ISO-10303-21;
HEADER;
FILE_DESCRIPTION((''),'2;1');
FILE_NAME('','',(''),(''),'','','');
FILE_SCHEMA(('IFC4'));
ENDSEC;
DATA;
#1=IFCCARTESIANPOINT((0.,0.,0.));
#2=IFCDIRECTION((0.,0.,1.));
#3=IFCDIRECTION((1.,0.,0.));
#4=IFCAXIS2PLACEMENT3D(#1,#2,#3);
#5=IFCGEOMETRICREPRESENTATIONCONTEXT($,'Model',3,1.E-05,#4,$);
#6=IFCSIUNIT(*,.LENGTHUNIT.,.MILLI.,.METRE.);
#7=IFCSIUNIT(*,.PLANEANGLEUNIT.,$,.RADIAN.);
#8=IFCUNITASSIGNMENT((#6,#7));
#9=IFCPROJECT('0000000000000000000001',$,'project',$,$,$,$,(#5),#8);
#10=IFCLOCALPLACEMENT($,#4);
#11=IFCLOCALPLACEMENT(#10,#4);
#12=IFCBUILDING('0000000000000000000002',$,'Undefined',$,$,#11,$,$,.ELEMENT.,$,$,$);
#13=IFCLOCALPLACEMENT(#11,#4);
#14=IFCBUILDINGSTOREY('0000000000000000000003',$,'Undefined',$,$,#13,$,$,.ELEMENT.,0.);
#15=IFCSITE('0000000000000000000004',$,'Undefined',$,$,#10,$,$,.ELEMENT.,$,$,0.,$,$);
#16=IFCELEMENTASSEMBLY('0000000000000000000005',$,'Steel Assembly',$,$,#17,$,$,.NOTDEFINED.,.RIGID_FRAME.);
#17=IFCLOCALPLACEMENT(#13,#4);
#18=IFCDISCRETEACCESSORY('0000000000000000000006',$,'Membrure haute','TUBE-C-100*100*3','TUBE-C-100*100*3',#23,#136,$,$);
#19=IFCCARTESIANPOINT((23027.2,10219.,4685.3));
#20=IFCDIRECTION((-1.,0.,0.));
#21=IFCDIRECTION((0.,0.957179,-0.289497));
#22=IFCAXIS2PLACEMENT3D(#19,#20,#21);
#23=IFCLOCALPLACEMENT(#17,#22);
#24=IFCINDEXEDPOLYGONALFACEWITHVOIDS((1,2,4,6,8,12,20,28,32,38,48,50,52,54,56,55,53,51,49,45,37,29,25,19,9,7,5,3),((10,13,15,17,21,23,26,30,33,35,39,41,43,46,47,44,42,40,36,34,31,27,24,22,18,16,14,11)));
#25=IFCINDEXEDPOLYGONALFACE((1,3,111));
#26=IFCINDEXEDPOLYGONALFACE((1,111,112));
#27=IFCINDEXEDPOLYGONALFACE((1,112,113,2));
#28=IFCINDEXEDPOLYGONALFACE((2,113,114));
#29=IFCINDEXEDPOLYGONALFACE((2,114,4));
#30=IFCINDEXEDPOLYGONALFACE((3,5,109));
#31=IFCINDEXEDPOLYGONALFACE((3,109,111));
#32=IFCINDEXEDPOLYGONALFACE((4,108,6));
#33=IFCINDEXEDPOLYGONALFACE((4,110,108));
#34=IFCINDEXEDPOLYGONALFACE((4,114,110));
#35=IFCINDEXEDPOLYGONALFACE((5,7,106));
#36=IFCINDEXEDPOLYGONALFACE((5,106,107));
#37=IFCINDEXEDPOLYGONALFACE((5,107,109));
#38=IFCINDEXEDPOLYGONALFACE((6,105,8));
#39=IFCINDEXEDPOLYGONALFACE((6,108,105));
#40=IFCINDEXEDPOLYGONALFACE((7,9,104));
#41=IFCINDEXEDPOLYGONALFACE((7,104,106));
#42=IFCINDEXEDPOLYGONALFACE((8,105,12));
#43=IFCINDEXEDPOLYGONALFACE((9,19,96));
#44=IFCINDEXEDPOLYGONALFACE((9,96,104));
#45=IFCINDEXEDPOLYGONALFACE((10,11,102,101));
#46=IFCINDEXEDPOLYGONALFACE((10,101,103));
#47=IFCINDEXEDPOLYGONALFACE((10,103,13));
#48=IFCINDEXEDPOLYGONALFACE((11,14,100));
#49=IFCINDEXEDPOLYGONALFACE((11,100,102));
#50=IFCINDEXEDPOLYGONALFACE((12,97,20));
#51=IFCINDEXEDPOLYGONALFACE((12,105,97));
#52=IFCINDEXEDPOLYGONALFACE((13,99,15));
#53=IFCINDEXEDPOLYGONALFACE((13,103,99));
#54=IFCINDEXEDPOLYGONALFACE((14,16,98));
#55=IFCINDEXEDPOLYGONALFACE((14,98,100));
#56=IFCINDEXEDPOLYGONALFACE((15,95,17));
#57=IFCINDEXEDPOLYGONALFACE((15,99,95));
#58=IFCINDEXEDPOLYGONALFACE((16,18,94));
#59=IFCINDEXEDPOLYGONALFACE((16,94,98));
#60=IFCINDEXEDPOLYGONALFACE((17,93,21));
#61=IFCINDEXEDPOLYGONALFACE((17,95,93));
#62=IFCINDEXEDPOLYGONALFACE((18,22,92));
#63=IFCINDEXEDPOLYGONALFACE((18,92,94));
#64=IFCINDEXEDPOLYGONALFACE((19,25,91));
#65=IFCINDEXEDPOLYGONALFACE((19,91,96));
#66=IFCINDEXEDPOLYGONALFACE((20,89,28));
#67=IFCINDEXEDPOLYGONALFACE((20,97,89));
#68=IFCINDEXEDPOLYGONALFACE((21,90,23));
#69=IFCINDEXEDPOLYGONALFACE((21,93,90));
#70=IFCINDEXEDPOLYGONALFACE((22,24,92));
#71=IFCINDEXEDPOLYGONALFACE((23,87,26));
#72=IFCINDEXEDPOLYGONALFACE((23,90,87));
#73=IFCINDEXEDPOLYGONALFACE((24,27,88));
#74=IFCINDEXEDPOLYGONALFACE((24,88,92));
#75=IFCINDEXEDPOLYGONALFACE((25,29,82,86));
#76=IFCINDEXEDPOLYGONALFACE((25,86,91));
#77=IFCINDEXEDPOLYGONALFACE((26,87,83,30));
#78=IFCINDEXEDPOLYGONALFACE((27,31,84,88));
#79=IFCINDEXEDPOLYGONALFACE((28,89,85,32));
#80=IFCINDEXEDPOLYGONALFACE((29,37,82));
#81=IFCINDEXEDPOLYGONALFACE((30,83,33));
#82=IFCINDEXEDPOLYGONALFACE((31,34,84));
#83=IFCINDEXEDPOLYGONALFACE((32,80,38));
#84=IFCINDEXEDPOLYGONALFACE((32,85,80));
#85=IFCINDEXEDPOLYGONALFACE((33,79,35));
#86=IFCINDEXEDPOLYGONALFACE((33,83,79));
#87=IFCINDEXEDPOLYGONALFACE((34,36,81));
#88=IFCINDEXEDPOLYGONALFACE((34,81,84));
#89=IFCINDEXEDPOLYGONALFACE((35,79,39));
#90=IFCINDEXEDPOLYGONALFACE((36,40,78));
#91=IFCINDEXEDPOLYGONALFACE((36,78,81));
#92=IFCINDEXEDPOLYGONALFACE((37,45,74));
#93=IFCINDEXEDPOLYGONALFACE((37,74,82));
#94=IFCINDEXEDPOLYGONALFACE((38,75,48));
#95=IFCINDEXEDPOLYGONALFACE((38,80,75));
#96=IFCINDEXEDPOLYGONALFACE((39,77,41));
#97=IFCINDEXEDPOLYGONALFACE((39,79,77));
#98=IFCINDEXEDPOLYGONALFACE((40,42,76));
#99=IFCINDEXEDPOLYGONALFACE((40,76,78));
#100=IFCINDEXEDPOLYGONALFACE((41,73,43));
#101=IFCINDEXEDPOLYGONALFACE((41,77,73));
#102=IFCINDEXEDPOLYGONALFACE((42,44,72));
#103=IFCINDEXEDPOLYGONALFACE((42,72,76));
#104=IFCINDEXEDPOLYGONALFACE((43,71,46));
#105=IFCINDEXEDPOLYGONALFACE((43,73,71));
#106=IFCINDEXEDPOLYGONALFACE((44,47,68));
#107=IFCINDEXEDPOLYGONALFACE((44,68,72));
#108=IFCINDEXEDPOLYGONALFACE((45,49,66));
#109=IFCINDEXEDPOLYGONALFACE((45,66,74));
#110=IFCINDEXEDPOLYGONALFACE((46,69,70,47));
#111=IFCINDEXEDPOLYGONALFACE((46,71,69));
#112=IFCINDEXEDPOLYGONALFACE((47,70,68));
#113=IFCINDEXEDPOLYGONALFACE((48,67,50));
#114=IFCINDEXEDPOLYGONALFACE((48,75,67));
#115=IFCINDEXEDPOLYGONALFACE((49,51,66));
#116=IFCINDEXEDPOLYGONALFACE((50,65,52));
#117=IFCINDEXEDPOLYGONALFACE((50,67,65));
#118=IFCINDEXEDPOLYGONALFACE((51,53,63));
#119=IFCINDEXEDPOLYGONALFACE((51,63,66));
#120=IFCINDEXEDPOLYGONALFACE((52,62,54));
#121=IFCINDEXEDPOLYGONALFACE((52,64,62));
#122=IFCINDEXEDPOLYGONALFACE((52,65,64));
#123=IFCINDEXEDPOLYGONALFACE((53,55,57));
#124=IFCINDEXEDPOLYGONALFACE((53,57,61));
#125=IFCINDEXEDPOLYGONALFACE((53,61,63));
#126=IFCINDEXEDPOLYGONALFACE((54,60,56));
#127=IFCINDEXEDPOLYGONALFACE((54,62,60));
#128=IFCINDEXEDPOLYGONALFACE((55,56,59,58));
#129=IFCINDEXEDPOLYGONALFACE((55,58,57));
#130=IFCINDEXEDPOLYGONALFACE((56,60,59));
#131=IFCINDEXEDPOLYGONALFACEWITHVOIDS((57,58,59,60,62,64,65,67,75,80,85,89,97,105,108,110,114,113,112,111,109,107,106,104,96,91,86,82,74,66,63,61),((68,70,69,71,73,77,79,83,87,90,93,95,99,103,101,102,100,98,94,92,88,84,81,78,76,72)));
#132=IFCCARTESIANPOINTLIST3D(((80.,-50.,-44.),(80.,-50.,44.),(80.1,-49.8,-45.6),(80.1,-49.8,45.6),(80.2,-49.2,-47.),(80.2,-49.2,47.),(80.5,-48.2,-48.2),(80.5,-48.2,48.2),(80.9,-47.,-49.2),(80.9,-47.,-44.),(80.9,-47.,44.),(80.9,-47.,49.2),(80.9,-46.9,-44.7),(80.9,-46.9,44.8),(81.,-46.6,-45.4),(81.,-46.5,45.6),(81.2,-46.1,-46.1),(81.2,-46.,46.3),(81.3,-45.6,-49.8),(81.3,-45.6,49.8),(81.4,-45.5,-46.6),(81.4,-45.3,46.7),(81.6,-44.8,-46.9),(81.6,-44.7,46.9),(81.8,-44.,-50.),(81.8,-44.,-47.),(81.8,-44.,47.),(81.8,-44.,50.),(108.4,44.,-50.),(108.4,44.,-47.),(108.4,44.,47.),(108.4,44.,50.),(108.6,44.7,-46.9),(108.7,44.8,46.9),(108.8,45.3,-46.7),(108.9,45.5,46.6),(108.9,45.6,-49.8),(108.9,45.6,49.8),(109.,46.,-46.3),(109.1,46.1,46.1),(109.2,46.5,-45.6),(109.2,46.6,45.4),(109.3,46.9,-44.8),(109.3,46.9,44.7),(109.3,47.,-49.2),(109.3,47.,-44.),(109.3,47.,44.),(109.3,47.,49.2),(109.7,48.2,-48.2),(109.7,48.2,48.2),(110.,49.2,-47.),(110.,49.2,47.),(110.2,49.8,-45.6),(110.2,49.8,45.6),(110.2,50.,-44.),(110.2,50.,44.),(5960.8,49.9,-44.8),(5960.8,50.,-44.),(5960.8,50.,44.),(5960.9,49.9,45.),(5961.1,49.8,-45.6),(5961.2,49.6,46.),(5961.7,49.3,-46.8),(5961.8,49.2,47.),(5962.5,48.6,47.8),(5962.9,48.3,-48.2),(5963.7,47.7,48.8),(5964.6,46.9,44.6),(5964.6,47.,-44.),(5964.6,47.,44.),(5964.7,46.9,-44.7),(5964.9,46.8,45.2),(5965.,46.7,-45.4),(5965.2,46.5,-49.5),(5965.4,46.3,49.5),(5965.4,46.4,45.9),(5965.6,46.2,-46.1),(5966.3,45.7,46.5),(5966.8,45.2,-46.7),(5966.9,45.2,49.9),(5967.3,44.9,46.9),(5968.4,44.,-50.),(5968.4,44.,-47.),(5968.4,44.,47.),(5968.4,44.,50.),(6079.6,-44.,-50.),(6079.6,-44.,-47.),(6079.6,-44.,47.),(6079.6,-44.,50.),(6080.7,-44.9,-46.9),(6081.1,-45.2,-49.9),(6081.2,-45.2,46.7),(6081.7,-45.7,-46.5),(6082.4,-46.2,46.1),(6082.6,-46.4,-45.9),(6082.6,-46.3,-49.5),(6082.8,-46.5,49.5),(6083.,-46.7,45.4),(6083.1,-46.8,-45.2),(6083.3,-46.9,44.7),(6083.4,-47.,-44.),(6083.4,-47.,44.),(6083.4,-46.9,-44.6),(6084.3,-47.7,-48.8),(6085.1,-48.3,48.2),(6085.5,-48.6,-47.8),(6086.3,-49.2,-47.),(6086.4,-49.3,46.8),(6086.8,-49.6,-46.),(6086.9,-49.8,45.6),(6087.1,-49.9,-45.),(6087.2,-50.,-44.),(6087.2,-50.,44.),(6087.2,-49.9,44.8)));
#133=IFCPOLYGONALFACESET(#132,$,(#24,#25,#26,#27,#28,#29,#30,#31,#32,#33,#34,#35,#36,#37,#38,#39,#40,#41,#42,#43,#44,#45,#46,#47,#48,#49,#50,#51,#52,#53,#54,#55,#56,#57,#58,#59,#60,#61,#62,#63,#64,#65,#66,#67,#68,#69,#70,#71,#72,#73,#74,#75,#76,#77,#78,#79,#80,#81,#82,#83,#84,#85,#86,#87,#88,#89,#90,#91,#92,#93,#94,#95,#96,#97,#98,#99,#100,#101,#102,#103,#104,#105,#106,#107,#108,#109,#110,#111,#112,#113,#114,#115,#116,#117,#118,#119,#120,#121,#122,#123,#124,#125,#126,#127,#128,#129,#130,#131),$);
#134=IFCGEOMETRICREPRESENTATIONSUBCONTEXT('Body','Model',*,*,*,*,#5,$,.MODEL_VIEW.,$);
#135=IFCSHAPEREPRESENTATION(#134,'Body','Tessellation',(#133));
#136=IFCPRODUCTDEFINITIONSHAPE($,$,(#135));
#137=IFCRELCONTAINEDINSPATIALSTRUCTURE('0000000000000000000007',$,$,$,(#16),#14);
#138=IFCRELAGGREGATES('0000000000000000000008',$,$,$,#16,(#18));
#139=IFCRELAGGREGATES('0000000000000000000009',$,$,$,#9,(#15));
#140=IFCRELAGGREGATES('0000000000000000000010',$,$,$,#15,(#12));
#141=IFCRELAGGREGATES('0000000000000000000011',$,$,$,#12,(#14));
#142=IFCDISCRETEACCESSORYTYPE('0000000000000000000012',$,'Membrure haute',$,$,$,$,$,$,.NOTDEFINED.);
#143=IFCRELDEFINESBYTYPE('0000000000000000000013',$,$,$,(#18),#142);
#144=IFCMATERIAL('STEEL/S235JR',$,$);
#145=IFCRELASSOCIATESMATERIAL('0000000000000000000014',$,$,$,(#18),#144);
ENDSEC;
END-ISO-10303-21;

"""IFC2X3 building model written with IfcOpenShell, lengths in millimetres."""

from ifc_helpers import new_model, si_unit, frame, origin_with_axes, origin_2d_with_axis, place, context, subcontext, project, spatial, hollow_rectangle, extrude, clip, halfspace, material, type_object, element, aggregate, save


model = new_model("IFC2X3")

# Units and contexts
model_context = context("Model", 3, precision=1e-05, world=origin_with_axes())
body_context = subcontext(model_context, "Body", "Model", "MODEL_VIEW")
ifc_project = project(units=[si_unit("LENGTHUNIT", "METRE", prefix="MILLI"), si_unit("PLANEANGLEUNIT", "RADIAN")], contexts=[model_context])

# Site, building, storey
site_placement = place(None, origin_with_axes())
site = spatial("IfcSite", under=ifc_project, at=site_placement, Name="Undefined", CompositionType="ELEMENT", RefElevation=0.0)
building_placement = place(site_placement, origin_with_axes())
building = spatial("IfcBuilding", under=site, at=building_placement, Name="Undefined", CompositionType="ELEMENT")
storey_placement = place(building_placement, origin_with_axes())
storey = spatial("IfcBuildingStorey", under=building, at=storey_placement, Name="Undefined", CompositionType="ELEMENT", Elevation=0.0)

# Element assembly, discrete accessory
ifc_material_1 = material(Name="STEEL/S235JR")
assembly_1_placement = place(storey_placement, origin_with_axes())
assembly_1 = element("IfcElementAssembly", 1, at=assembly_1_placement, inside=storey, Name="Steel Assembly", AssemblyPlace="NOTDEFINED", PredefinedType="RIGID_FRAME")
discrete_accessory_type_1 = type_object("IfcDiscreteAccessoryType", Name="Membrure haute")
discrete_accessory_1_placement = place(assembly_1_placement, frame((23027.2, 10219.0, 4685.3), z_axis=(-1.0, 0.0, 0.0), x_axis=(0.0, 0.957179, -0.289497)))
discrete_accessory_1 = element("IfcDiscreteAccessory", 2, at=discrete_accessory_1_placement, type_object=discrete_accessory_type_1, material=ifc_material_1, Name="Membrure haute", Description="TUBE-C-100*100*3", ObjectType="TUBE-C-100*100*3", context=body_context, shape_type="Clipping", body=[
    clip(clip(extrude(hollow_rectangle(XDim=100.0, YDim=100.0, WallThickness=3.0, InnerFilletRadius=3.0, OuterFilletRadius=6.0, at=origin_2d_with_axis()), frame((6120.4, 0.0, 0.0), z_axis=(-1.0, 0.0, 0.0), x_axis=(0.0, -1.0, 0.0)), (0.0, 0.0, 1.0), 6121.7), halfspace(frame((5960.8, 50.0, -50.0), z_axis=(0.62025, 0.784404, 0.0), x_axis=(0.0, 0.0, -1.0)), False)), halfspace(frame((64.4, -101.5, 0.0), z_axis=(-0.957179, 0.289497, 0.0), x_axis=(0.0, 0.0, -1.0)), False)),
])
aggregate(assembly_1, [discrete_accessory_1])

save(model, "model.ifc")
